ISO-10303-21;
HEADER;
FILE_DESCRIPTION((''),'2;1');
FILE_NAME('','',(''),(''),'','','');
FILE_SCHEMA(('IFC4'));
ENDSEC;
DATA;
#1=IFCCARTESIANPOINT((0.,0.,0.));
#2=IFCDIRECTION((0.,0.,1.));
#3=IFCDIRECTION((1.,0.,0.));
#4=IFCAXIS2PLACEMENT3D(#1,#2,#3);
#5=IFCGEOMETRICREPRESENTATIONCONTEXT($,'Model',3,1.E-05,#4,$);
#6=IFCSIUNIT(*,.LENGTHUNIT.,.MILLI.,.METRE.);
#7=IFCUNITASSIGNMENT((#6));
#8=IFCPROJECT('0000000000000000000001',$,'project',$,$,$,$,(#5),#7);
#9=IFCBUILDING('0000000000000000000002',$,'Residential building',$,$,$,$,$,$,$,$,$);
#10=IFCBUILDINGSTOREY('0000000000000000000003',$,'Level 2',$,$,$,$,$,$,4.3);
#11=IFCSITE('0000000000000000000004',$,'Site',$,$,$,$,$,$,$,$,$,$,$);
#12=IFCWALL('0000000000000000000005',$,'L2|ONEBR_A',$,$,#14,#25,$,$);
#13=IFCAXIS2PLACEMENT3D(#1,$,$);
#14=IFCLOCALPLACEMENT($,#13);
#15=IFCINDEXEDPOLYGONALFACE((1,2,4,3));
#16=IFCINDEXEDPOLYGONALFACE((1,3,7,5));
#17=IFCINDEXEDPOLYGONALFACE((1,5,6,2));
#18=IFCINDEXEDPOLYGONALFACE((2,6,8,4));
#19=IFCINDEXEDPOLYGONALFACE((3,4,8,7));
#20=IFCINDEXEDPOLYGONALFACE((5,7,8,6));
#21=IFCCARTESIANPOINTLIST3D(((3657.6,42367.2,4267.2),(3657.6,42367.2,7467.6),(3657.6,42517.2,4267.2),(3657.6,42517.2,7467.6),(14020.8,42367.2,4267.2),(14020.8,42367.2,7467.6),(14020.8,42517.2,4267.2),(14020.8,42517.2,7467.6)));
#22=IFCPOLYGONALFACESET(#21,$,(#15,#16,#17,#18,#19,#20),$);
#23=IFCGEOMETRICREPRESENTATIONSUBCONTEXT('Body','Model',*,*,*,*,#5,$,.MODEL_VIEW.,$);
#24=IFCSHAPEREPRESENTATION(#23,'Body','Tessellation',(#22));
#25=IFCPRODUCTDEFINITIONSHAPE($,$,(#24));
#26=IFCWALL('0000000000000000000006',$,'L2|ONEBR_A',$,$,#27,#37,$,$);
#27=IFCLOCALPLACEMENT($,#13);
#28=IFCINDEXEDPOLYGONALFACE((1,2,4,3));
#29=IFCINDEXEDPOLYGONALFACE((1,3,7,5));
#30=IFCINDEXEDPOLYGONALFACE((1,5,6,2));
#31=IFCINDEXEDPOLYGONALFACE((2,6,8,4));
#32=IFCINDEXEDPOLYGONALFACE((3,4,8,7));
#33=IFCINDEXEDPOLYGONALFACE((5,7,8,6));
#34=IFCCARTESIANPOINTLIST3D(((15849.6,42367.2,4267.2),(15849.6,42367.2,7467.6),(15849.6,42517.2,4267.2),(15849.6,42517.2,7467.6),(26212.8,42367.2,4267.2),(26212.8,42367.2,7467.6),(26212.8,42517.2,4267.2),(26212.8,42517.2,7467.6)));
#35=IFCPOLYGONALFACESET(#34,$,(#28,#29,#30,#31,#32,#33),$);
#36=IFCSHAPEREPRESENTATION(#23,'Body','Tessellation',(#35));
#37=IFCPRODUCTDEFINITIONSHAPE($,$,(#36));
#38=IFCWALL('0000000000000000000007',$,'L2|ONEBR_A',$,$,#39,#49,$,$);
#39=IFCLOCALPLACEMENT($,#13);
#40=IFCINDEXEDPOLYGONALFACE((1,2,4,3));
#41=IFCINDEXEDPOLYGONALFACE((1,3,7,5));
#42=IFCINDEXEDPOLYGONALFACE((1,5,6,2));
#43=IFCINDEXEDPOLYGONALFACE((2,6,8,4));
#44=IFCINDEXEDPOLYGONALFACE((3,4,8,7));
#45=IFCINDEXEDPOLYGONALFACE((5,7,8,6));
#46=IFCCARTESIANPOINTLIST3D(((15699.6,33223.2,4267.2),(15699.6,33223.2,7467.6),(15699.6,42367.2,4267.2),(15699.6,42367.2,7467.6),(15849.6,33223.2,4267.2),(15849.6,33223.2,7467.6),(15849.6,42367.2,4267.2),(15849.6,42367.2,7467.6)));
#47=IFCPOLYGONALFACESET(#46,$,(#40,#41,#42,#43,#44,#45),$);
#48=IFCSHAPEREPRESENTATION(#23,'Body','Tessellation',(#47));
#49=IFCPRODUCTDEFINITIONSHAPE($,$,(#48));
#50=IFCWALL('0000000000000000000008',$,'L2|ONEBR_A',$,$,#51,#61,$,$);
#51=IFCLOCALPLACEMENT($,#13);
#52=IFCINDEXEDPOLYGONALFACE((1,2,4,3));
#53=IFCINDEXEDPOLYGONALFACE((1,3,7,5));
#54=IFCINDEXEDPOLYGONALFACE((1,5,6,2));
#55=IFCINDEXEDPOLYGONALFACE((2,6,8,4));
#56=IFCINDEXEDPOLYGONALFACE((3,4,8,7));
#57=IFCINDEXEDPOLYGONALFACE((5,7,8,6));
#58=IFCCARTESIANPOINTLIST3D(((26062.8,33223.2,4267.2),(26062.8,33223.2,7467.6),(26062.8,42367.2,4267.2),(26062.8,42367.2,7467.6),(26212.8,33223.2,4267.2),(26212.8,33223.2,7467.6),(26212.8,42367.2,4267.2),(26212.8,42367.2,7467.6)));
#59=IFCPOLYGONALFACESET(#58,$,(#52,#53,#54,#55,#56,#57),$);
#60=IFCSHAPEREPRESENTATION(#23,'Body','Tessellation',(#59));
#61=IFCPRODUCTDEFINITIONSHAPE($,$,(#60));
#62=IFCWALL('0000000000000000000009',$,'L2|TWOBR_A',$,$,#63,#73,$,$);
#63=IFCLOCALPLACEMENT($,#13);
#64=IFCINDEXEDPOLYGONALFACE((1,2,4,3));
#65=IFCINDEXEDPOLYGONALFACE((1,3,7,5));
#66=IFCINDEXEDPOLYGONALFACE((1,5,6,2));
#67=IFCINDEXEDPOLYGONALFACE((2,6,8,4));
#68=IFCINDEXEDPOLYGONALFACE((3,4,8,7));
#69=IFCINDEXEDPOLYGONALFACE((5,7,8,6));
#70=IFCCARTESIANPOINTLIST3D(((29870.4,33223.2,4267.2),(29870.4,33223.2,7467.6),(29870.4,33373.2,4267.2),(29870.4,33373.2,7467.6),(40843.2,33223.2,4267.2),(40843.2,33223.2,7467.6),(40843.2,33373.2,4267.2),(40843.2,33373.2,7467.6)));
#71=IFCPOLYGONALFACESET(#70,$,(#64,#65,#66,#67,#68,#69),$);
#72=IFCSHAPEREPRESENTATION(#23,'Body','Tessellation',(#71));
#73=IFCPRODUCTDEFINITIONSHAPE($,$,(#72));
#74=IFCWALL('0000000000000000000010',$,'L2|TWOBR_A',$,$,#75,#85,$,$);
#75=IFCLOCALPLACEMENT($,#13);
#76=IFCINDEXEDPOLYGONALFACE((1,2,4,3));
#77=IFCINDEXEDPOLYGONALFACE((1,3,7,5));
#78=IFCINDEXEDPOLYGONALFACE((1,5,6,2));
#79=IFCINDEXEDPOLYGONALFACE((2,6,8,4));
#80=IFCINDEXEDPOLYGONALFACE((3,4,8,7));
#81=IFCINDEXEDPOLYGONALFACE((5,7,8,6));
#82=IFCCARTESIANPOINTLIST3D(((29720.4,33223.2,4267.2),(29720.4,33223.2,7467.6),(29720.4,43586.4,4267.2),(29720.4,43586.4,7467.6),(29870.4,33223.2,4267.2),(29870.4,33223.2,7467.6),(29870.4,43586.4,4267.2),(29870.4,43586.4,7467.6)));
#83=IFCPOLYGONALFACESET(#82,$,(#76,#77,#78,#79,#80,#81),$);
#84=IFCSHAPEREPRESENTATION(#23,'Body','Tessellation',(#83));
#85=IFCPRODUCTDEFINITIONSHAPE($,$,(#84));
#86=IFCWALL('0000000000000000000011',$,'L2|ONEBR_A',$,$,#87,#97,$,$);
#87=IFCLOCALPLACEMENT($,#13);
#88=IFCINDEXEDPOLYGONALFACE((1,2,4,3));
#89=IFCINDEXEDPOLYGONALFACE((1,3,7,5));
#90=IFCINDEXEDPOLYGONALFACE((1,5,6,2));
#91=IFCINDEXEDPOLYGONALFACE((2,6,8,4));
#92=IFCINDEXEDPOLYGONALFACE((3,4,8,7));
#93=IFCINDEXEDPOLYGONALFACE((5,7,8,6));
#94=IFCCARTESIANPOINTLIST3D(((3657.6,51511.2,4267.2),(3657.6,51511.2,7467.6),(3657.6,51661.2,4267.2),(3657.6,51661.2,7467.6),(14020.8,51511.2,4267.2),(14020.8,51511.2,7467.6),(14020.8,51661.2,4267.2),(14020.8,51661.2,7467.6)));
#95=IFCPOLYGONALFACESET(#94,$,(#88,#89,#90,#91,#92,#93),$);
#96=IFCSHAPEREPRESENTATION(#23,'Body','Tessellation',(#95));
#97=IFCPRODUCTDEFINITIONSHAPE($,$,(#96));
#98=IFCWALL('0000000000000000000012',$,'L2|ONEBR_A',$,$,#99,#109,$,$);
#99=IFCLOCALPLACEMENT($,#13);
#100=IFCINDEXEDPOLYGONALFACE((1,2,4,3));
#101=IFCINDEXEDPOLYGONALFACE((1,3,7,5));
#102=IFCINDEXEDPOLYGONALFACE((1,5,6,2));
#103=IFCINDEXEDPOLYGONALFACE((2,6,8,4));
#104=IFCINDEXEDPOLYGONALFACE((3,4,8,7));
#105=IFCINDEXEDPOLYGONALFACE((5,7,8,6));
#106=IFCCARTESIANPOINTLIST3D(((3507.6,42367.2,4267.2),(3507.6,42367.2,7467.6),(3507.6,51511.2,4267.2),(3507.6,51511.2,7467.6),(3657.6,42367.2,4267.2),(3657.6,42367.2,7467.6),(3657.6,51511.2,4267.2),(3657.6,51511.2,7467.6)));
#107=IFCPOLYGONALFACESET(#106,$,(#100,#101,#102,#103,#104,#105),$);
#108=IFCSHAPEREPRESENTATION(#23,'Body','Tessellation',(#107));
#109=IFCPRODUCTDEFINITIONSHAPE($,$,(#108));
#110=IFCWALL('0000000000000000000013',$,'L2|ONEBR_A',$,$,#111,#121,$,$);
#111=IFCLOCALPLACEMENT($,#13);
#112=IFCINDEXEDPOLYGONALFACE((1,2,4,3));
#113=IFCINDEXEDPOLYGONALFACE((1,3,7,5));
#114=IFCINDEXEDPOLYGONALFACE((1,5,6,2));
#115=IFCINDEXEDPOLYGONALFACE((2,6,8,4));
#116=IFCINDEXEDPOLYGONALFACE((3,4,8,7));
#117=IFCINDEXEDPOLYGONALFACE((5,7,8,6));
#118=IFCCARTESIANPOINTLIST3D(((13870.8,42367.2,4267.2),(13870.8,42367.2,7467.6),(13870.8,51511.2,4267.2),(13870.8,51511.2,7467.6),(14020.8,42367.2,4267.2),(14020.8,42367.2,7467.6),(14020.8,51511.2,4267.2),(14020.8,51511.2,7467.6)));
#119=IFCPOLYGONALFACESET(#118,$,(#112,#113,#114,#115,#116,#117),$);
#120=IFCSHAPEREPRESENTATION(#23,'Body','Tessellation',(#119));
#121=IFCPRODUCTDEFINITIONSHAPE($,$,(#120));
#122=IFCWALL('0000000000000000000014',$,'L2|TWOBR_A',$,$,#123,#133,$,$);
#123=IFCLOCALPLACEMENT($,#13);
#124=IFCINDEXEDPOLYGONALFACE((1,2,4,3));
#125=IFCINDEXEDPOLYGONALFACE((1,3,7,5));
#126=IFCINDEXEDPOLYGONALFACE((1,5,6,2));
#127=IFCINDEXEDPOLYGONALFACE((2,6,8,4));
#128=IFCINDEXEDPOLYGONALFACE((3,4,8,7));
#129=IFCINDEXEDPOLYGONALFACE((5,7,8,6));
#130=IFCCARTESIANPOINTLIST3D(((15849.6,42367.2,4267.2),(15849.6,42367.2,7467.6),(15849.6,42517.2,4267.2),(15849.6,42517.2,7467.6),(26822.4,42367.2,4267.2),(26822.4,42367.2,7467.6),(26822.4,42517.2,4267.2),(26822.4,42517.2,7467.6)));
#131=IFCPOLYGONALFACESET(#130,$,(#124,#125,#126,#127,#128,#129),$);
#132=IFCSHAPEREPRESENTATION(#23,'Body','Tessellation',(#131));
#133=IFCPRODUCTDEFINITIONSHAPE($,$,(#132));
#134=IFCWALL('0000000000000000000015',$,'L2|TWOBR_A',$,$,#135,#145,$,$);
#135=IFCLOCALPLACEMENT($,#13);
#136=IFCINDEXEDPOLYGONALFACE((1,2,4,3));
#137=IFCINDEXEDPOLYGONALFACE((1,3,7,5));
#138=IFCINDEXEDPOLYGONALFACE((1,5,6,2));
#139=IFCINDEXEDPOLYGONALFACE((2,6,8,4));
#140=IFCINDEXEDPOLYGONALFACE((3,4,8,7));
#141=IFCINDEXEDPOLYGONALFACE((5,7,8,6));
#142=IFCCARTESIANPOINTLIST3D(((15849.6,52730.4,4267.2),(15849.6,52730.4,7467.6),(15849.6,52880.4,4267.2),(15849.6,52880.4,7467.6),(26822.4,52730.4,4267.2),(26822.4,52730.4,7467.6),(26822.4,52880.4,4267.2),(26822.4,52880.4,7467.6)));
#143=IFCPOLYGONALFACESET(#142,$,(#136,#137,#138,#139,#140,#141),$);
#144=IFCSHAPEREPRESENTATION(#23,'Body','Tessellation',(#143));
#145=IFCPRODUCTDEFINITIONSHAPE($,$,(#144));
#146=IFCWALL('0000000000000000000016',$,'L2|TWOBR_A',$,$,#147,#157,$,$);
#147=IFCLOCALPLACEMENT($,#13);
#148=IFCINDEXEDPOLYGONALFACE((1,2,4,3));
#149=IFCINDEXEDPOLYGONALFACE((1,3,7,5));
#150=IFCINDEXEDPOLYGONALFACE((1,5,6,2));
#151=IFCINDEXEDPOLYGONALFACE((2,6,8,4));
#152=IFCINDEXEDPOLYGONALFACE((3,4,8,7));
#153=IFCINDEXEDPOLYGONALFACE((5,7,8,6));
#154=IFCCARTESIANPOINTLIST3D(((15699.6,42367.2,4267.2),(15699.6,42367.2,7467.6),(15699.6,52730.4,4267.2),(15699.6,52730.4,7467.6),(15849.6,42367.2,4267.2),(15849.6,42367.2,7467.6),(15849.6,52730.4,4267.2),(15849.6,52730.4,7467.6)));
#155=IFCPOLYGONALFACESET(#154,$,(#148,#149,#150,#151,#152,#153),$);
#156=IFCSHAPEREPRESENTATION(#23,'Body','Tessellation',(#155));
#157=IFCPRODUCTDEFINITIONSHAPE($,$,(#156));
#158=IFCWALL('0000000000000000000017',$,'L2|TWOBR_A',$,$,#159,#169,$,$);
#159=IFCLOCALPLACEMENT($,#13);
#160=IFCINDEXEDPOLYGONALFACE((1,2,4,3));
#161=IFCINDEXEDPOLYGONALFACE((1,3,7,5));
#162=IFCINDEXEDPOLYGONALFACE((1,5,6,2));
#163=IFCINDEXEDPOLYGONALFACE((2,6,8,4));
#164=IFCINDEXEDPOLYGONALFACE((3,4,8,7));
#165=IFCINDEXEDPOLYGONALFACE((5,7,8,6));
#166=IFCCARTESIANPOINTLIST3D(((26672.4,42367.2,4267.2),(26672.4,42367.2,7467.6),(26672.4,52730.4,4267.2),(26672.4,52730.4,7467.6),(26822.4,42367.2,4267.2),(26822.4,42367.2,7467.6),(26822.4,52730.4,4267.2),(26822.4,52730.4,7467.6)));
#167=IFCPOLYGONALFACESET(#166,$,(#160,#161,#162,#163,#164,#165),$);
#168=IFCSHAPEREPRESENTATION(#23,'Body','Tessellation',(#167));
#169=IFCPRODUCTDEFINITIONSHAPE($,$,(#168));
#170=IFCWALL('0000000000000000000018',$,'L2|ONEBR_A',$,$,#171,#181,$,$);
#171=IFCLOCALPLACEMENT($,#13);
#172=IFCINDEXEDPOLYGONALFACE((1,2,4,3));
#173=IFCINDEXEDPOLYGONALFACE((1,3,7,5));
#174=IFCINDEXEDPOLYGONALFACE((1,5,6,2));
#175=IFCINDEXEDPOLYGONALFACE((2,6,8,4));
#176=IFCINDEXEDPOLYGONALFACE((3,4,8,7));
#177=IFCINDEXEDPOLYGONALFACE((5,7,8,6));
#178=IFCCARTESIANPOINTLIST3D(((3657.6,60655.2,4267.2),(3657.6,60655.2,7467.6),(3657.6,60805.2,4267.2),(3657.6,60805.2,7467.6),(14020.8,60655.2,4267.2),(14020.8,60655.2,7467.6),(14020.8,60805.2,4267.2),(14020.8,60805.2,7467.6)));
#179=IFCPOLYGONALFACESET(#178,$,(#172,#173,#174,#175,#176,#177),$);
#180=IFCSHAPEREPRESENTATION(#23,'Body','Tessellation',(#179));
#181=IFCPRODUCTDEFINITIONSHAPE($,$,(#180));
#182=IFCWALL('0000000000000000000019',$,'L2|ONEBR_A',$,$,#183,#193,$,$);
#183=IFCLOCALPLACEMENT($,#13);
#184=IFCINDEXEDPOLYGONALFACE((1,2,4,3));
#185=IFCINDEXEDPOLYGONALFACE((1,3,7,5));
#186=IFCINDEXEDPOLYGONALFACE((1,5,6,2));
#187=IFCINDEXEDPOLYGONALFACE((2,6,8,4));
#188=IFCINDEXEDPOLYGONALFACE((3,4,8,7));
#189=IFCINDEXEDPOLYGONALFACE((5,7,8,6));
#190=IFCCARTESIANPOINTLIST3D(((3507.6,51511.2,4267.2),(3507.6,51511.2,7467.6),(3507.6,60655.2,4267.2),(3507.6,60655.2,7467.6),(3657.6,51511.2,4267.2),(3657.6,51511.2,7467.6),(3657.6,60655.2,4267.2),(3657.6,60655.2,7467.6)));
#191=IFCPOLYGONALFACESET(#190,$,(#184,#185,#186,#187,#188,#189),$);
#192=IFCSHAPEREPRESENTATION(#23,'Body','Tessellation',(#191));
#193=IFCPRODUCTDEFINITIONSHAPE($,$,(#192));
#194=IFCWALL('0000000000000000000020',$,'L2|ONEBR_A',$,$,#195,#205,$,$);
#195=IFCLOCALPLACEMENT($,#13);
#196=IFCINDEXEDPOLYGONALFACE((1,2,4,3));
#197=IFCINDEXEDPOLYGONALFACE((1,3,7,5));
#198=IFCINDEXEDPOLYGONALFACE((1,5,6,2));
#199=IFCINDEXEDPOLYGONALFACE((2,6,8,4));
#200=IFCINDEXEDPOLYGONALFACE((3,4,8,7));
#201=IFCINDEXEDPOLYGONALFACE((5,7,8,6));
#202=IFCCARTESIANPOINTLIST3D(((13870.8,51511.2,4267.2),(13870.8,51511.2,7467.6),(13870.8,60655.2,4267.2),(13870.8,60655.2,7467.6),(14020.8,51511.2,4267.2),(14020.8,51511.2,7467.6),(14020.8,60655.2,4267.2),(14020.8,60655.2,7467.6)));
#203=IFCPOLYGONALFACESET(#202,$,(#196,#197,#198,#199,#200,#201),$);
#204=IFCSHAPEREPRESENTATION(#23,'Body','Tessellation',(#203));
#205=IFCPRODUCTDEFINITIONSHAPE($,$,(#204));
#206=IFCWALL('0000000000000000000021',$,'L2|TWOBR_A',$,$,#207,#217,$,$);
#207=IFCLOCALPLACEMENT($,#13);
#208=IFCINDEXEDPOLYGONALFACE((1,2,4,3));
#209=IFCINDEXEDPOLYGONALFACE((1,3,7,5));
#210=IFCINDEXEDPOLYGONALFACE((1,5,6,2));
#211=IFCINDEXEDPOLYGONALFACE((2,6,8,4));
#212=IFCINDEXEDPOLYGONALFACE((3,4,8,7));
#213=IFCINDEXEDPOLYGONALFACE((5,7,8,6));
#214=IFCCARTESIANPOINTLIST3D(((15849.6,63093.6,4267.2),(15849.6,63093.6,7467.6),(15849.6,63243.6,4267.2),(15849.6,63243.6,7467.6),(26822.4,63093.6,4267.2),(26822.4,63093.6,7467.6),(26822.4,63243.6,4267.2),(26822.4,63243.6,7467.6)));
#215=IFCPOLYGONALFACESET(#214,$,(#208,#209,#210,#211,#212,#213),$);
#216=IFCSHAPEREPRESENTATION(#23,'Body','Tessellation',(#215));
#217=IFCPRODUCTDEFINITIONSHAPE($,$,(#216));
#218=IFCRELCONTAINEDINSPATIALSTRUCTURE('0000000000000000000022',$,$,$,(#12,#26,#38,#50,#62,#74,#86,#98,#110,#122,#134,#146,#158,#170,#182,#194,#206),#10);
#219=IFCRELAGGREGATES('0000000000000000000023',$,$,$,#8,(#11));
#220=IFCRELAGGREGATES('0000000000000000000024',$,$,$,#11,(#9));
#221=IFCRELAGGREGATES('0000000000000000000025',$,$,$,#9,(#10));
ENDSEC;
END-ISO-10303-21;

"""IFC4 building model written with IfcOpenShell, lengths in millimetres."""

from ifc_helpers import new_model, si_unit, frame, origin_with_axes, place, context, subcontext, project, spatial, indexed_curve, outline, extrude, element, save


model = new_model("IFC4")

# Units and contexts
model_context = context("Model", 3, precision=1e-05, world=origin_with_axes())
body_context = subcontext(model_context, "Body", "Model", "MODEL_VIEW")
ifc_project = project(units=[si_unit("LENGTHUNIT", "METRE", prefix="MILLI")], contexts=[model_context])

# Site, building, storey
site = spatial("IfcSite", under=ifc_project, Name="Site")
building = spatial("IfcBuilding", under=site, Name="Residential building")
storey = spatial("IfcBuildingStorey", under=building, Name="Level 2", Elevation=4.3)

# Walls
for number, where, z_axis, x_axis, name in (
    (1, (3657.6, 42367.2, 4267.2), (0.0, 0.0, 1.0), (1.0, 0.0, 0.0), "L2|ONEBR_A"),
    (2, (15849.6, 42367.2, 4267.2), (0.0, 0.0, 1.0), (1.0, 0.0, 0.0), "L2|ONEBR_A"),
):
    element("IfcWall", number, at=place(None, frame(where, z_axis=z_axis, x_axis=x_axis)), inside=storey, Name=name, context=body_context, shape_type="SweptSolid", body=[
        extrude(outline(indexed_curve([(0.0, 0.0), (0.0, 150.0), (10363.2, 150.0), (10363.2, 0.0), (0.0, 0.0)], self_intersect=False)), origin_with_axes(), (0.0, 0.0, 1.0), 3200.4),
    ])
for number, where, z_axis, x_axis, name in (
    (3, (15849.6, 33223.2, 4267.2), (0.0, 0.0, 1.0), (0.0, 1.0, 0.0), "L2|ONEBR_A"),
    (4, (26212.8, 33223.2, 4267.2), (0.0, 0.0, 1.0), (0.0, 1.0, 0.0), "L2|ONEBR_A"),
):
    element("IfcWall", number, at=place(None, frame(where, z_axis=z_axis, x_axis=x_axis)), inside=storey, Name=name, context=body_context, shape_type="SweptSolid", body=[
        extrude(outline(indexed_curve([(0.0, 0.0), (0.0, 150.0), (9144.0, 150.0), (9144.0, 0.0), (0.0, 0.0)], self_intersect=False)), origin_with_axes(), (0.0, 0.0, 1.0), 3200.4),
    ])
wall_placement = place(None, frame((29870.4, 33223.2, 4267.2), z_axis=(0.0, 0.0, 1.0), x_axis=(1.0, 0.0, 0.0)))
element("IfcWall", 5, at=wall_placement, inside=storey, Name="L2|TWOBR_A", context=body_context, shape_type="SweptSolid", body=[
    extrude(outline(indexed_curve([(0.0, 0.0), (0.0, 150.0), (10972.8, 150.0), (10972.8, 0.0), (0.0, 0.0)], self_intersect=False)), origin_with_axes(), (0.0, 0.0, 1.0), 3200.4),
])
for number, where, z_axis, x_axis, name in (
    (6, (29870.4, 33223.2, 4267.2), (0.0, 0.0, 1.0), (0.0, 1.0, 0.0), "L2|TWOBR_A"),
    (7, (3657.6, 51511.2, 4267.2), (0.0, 0.0, 1.0), (1.0, 0.0, 0.0), "L2|ONEBR_A"),
):
    element("IfcWall", number, at=place(None, frame(where, z_axis=z_axis, x_axis=x_axis)), inside=storey, Name=name, context=body_context, shape_type="SweptSolid", body=[
        extrude(outline(indexed_curve([(0.0, 0.0), (0.0, 150.0), (10363.2, 150.0), (10363.2, 0.0), (0.0, 0.0)], self_intersect=False)), origin_with_axes(), (0.0, 0.0, 1.0), 3200.4),
    ])
for number, where, z_axis, x_axis, name in (
    (8, (3657.6, 42367.2, 4267.2), (0.0, 0.0, 1.0), (0.0, 1.0, 0.0), "L2|ONEBR_A"),
    (9, (14020.8, 42367.2, 4267.2), (0.0, 0.0, 1.0), (0.0, 1.0, 0.0), "L2|ONEBR_A"),
):
    element("IfcWall", number, at=place(None, frame(where, z_axis=z_axis, x_axis=x_axis)), inside=storey, Name=name, context=body_context, shape_type="SweptSolid", body=[
        extrude(outline(indexed_curve([(0.0, 0.0), (0.0, 150.0), (9144.0, 150.0), (9144.0, 0.0), (0.0, 0.0)], self_intersect=False)), origin_with_axes(), (0.0, 0.0, 1.0), 3200.4),
    ])
for number, where, z_axis, x_axis, name in (
    (10, (15849.6, 42367.2, 4267.2), (0.0, 0.0, 1.0), (1.0, 0.0, 0.0), "L2|TWOBR_A"),
    (11, (15849.6, 52730.4, 4267.2), (0.0, 0.0, 1.0), (1.0, 0.0, 0.0), "L2|TWOBR_A"),
):
    element("IfcWall", number, at=place(None, frame(where, z_axis=z_axis, x_axis=x_axis)), inside=storey, Name=name, context=body_context, shape_type="SweptSolid", body=[
        extrude(outline(indexed_curve([(0.0, 0.0), (0.0, 150.0), (10972.8, 150.0), (10972.8, 0.0), (0.0, 0.0)], self_intersect=False)), origin_with_axes(), (0.0, 0.0, 1.0), 3200.4),
    ])
for number, where, z_axis, x_axis, name in (
    (12, (15849.6, 42367.2, 4267.2), (0.0, 0.0, 1.0), (0.0, 1.0, 0.0), "L2|TWOBR_A"),
    (13, (26822.4, 42367.2, 4267.2), (0.0, 0.0, 1.0), (0.0, 1.0, 0.0), "L2|TWOBR_A"),
    (14, (3657.6, 60655.2, 4267.2), (0.0, 0.0, 1.0), (1.0, 0.0, 0.0), "L2|ONEBR_A"),
):
    element("IfcWall", number, at=place(None, frame(where, z_axis=z_axis, x_axis=x_axis)), inside=storey, Name=name, context=body_context, shape_type="SweptSolid", body=[
        extrude(outline(indexed_curve([(0.0, 0.0), (0.0, 150.0), (10363.2, 150.0), (10363.2, 0.0), (0.0, 0.0)], self_intersect=False)), origin_with_axes(), (0.0, 0.0, 1.0), 3200.4),
    ])
for number, where, z_axis, x_axis, name in (
    (15, (3657.6, 51511.2, 4267.2), (0.0, 0.0, 1.0), (0.0, 1.0, 0.0), "L2|ONEBR_A"),
    (16, (14020.8, 51511.2, 4267.2), (0.0, 0.0, 1.0), (0.0, 1.0, 0.0), "L2|ONEBR_A"),
):
    element("IfcWall", number, at=place(None, frame(where, z_axis=z_axis, x_axis=x_axis)), inside=storey, Name=name, context=body_context, shape_type="SweptSolid", body=[
        extrude(outline(indexed_curve([(0.0, 0.0), (0.0, 150.0), (9144.0, 150.0), (9144.0, 0.0), (0.0, 0.0)], self_intersect=False)), origin_with_axes(), (0.0, 0.0, 1.0), 3200.4),
    ])
for number, where, z_axis, x_axis, name in (
    (17, (15849.6, 63093.6, 4267.2), (0.0, 0.0, 1.0), (1.0, 0.0, 0.0), "L2|TWOBR_A"),
):
    element("IfcWall", number, at=place(None, frame(where, z_axis=z_axis, x_axis=x_axis)), inside=storey, Name=name, context=body_context, shape_type="SweptSolid", body=[
        extrude(outline(indexed_curve([(0.0, 0.0), (0.0, 150.0), (10972.8, 150.0), (10972.8, 0.0), (0.0, 0.0)], self_intersect=False)), origin_with_axes(), (0.0, 0.0, 1.0), 3200.4),
    ])

save(model, "model.ifc")
